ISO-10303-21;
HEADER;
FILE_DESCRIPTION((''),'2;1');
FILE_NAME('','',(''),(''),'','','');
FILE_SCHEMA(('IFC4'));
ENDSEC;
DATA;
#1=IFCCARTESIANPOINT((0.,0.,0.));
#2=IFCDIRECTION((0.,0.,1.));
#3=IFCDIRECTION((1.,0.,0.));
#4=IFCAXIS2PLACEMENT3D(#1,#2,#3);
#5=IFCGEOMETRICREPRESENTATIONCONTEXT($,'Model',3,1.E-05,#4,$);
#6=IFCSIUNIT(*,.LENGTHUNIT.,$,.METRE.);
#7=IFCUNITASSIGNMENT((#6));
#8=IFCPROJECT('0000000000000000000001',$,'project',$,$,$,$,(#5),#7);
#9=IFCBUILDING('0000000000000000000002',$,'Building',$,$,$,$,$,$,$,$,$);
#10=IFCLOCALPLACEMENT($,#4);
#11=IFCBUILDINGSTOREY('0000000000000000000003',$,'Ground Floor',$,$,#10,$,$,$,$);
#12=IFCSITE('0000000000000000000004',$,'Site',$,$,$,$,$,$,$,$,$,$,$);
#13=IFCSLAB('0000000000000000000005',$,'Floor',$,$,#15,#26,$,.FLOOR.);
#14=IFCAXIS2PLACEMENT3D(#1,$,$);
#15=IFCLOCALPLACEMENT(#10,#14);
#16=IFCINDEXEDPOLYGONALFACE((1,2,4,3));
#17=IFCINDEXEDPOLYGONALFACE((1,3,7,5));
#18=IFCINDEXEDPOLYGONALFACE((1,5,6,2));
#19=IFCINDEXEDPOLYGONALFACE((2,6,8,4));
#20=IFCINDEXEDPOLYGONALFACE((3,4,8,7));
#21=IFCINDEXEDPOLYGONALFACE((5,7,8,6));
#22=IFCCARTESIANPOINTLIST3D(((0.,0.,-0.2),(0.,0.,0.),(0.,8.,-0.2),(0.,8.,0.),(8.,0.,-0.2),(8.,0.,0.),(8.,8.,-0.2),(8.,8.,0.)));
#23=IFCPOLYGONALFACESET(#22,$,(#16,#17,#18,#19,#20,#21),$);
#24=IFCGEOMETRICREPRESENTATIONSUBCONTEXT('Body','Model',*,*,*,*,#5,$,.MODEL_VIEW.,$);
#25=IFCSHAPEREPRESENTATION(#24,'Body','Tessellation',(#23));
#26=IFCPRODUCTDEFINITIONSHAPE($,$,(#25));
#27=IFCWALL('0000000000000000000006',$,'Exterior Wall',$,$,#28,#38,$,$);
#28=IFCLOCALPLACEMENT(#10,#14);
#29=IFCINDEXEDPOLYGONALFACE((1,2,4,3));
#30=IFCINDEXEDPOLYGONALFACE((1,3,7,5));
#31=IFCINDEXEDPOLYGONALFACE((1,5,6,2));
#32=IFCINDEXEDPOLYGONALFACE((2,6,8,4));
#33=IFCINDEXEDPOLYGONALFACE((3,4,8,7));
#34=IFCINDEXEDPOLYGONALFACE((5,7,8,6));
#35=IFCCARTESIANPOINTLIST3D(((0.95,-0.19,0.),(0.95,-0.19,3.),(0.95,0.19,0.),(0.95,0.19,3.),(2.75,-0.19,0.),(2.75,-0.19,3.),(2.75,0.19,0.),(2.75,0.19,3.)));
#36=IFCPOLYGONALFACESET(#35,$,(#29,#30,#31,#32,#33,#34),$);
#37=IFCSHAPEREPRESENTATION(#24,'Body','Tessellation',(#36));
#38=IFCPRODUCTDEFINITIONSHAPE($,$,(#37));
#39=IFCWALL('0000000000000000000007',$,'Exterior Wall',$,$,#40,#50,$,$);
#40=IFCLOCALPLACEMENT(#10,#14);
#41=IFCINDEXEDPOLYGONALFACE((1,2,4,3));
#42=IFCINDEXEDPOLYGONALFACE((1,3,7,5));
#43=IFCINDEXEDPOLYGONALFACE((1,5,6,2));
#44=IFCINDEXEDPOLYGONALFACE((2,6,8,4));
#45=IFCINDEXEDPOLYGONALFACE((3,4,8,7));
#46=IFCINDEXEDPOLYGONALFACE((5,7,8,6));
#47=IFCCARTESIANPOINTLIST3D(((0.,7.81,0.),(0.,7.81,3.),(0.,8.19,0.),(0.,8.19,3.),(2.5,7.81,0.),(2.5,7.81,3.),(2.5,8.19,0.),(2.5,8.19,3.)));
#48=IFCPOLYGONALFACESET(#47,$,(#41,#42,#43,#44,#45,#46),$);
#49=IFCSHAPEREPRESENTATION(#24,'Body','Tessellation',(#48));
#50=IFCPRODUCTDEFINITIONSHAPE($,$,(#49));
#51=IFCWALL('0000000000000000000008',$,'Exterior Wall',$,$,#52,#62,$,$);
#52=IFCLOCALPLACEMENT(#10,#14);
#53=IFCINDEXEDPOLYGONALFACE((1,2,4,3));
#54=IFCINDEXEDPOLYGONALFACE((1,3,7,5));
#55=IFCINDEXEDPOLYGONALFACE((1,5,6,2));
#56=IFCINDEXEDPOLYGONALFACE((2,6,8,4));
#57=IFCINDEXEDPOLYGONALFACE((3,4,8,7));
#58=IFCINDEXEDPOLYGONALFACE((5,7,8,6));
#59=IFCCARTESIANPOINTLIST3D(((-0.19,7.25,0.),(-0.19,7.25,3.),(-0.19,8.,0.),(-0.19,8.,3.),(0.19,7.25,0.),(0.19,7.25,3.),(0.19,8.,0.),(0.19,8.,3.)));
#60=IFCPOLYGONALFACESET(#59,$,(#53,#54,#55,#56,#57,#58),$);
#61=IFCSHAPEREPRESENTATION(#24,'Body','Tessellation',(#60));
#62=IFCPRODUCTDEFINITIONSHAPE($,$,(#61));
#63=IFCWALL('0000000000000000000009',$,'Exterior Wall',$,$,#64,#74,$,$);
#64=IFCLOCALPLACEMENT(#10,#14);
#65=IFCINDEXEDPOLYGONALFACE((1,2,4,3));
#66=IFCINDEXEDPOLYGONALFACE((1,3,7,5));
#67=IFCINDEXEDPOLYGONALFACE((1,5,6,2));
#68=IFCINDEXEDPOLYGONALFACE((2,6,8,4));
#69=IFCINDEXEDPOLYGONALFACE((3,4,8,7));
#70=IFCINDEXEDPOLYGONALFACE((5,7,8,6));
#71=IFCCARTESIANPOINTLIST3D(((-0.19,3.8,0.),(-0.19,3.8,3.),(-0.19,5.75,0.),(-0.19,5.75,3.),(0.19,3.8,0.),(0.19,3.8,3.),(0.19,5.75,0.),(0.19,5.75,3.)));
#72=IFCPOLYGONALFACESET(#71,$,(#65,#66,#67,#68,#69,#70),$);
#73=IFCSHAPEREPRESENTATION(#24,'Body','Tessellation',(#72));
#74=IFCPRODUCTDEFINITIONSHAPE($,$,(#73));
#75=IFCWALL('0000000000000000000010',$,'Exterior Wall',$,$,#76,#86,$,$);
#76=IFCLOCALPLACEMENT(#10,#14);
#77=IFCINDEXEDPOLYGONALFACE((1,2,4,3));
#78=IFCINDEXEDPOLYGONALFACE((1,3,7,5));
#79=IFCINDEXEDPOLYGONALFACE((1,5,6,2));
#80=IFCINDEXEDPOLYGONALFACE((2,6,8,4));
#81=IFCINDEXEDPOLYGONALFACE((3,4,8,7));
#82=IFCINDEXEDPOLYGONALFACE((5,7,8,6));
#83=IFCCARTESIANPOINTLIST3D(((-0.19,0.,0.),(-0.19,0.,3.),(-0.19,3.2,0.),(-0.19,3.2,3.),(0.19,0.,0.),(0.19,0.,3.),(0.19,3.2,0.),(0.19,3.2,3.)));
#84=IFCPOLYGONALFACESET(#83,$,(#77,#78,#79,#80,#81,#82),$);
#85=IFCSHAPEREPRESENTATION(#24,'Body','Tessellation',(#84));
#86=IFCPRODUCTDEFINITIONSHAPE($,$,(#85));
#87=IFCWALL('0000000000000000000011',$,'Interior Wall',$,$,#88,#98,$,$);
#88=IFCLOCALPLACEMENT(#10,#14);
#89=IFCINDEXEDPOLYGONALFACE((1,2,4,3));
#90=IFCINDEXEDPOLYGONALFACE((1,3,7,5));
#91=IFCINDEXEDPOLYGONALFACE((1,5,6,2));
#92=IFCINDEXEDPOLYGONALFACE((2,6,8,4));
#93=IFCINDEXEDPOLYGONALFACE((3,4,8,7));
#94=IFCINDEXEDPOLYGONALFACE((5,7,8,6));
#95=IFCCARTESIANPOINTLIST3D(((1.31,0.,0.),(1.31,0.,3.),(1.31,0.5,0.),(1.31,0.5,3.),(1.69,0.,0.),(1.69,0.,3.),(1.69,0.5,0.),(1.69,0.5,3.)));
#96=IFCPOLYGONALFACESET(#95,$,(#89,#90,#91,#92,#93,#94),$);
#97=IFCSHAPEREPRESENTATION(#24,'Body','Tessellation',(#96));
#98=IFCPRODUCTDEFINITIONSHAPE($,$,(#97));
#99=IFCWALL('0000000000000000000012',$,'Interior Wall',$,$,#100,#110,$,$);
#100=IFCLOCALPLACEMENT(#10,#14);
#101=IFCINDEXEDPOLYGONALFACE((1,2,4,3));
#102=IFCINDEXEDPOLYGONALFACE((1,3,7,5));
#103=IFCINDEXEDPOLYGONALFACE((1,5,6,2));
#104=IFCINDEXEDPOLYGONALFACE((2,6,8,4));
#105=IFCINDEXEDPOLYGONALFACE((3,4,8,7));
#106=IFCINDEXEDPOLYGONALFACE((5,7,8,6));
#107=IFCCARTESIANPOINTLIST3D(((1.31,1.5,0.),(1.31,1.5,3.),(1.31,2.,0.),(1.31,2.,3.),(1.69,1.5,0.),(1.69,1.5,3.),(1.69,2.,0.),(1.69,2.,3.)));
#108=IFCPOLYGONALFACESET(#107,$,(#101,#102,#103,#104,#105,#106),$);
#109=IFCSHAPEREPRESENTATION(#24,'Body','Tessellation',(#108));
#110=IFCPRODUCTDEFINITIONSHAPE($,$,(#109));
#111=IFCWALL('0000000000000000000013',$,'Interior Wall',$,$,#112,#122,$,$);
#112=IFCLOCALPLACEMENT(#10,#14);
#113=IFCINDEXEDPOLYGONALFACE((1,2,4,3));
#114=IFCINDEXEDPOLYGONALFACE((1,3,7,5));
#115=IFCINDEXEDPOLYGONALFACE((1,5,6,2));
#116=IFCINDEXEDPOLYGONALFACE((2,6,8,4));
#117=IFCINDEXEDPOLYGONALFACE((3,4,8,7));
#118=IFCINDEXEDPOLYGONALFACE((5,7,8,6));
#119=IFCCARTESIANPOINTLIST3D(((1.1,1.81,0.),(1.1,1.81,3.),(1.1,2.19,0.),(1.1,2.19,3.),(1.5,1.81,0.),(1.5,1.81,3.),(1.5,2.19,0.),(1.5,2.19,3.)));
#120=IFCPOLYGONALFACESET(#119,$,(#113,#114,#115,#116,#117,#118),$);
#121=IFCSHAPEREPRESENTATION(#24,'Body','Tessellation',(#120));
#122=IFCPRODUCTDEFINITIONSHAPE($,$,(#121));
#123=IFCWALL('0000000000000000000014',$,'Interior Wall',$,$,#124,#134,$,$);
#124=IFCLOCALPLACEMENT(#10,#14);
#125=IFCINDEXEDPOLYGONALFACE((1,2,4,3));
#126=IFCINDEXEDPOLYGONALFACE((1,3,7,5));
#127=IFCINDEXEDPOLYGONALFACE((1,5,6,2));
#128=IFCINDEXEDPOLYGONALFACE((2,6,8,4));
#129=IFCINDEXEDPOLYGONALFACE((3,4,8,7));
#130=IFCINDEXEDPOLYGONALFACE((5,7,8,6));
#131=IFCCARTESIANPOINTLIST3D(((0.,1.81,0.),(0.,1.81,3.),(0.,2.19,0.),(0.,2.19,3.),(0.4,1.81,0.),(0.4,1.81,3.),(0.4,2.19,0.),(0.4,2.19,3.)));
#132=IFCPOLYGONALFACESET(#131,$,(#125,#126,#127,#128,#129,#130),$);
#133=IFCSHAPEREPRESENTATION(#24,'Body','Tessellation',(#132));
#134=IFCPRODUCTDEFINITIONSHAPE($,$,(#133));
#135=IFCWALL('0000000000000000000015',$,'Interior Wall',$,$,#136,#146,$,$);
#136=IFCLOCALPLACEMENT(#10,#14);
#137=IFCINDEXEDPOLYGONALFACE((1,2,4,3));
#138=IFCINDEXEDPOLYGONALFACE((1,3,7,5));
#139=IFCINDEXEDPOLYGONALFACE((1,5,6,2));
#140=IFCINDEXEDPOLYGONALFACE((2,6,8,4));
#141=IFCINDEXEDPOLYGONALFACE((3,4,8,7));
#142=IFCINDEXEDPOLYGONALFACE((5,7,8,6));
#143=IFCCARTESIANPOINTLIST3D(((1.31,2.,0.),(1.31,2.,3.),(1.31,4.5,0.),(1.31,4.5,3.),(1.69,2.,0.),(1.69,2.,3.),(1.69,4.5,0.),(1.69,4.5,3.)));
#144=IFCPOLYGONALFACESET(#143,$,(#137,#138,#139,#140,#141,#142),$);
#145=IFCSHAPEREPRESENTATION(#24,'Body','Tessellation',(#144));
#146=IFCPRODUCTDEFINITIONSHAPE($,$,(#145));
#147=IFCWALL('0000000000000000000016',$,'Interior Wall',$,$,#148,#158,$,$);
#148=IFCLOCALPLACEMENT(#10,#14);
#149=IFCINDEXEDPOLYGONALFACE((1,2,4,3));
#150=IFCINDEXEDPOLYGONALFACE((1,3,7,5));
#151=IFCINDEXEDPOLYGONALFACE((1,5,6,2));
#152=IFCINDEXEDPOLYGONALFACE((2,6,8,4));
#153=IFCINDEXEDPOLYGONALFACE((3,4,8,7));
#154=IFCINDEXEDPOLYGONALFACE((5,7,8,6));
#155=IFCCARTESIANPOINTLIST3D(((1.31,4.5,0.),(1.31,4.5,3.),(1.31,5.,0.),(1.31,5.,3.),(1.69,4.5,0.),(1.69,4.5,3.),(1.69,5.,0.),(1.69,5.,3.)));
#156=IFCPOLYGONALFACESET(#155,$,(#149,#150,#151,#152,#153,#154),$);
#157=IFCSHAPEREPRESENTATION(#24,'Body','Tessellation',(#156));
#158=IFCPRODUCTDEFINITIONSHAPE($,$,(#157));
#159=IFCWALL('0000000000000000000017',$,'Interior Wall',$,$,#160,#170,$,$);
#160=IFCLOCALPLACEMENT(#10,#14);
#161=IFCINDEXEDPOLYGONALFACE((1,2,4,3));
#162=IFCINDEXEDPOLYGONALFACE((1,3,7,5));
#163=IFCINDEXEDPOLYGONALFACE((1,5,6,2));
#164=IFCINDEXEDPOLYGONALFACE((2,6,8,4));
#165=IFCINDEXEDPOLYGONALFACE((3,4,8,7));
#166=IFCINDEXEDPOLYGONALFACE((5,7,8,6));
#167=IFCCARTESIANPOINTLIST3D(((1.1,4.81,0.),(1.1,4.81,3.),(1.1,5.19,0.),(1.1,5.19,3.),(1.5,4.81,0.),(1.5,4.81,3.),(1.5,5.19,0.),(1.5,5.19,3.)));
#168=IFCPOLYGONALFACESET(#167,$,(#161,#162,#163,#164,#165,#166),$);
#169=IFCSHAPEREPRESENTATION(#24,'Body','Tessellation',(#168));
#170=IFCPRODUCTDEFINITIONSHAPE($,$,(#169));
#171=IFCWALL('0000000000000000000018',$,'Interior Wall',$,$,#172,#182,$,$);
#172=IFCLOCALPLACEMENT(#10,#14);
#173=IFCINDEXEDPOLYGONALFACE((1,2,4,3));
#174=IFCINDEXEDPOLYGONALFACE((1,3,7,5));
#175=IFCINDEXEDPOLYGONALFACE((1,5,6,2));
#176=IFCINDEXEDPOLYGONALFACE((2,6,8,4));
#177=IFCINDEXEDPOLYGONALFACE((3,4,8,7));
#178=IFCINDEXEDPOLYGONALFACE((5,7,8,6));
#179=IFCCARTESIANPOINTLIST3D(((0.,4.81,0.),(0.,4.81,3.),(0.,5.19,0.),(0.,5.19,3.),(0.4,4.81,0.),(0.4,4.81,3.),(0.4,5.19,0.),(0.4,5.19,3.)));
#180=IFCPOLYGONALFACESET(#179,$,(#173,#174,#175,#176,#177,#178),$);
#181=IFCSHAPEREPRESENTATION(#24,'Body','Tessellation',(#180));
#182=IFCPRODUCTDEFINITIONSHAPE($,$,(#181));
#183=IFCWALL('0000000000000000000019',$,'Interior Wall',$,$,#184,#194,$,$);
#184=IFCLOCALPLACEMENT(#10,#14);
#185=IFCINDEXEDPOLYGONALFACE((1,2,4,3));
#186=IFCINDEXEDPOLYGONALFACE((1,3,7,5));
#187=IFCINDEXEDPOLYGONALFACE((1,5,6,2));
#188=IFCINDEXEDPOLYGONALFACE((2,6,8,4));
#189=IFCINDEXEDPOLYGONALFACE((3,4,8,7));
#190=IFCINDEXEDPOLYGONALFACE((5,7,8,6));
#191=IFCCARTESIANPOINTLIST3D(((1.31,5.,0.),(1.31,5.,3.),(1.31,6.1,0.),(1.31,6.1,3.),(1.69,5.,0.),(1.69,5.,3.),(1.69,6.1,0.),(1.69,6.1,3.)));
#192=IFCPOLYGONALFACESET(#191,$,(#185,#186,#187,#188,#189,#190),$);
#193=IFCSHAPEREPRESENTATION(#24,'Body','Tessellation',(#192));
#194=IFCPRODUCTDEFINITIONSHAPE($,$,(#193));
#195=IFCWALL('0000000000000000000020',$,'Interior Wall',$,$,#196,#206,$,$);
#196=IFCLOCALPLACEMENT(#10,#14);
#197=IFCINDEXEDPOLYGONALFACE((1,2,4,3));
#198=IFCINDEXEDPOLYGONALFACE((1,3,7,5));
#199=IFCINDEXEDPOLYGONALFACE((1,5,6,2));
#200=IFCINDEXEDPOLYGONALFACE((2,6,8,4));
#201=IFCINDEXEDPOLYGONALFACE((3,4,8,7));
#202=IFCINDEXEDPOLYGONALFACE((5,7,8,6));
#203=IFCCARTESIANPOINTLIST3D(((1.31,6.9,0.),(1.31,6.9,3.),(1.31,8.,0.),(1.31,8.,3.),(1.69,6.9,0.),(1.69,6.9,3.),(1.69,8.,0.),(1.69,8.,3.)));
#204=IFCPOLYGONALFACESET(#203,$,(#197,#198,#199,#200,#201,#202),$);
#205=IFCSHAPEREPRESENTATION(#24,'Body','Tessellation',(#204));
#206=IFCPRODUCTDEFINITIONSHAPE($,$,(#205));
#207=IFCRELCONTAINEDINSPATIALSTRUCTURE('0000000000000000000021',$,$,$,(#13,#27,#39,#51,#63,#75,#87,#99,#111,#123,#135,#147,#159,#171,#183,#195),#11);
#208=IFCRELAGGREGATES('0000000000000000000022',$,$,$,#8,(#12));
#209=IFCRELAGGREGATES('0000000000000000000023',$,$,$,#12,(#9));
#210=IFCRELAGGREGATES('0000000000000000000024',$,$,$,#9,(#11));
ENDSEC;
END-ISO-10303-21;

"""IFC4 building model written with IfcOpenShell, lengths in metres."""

from ifc_helpers import new_model, si_unit, frame, origin_with_axes, place, context, subcontext, project, spatial, indexed_curve, outline, extrude, element, save


model = new_model("IFC4")

# Units and contexts
model_context = context("Model", 3, precision=1e-05, world=origin_with_axes())
body_context = subcontext(model_context, "Body", "Model", "MODEL_VIEW")
ifc_project = project(units=[si_unit("LENGTHUNIT", "METRE")], contexts=[model_context])

# Site, building, storey
site = spatial("IfcSite", under=ifc_project, Name="Site")
building = spatial("IfcBuilding", under=site, Name="Building")
storey_placement = place(None, origin_with_axes())
storey = spatial("IfcBuildingStorey", under=building, at=storey_placement, Name="Ground Floor")

# Slab
slab_placement = place(storey_placement, frame((0.0, 0.0, -0.2), z_axis=(0.0, 0.0, 1.0), x_axis=(1.0, 0.0, 0.0)))
element("IfcSlab", 1, at=slab_placement, inside=storey, Name="Floor", PredefinedType="FLOOR", context=body_context, shape_type="SweptSolid", body=[
    extrude(outline(indexed_curve([(0.0, 0.0), (8.0, 0.0), (8.0, 8.0), (0.0, 8.0)])), None, (0.0, 0.0, 1.0), 0.2),
])

# Walls
wall_1_placement = place(storey_placement, frame((0.95, 0.0, 0.0), z_axis=(0.0, 0.0, 1.0), x_axis=(1.0, 0.0, 0.0)))
element("IfcWall", 2, at=wall_1_placement, inside=storey, Name="Exterior Wall", context=body_context, shape_type="SweptSolid", body=[
    extrude(outline(indexed_curve([(0.0, 0.0), (0.0, 0.38), (1.8, 0.38), (1.8, 0.0), (0.0, 0.0)], self_intersect=False)), frame((0.0, -0.19, 0.0), z_axis=(0.0, 0.0, 1.0), x_axis=(1.0, 0.0, 0.0)), (0.0, 0.0, 1.0), 3.0),
])
wall_2_placement = place(storey_placement, frame((2.5, 8.0, 0.0), z_axis=(0.0, 0.0, 1.0), x_axis=(-1.0, 0.0, 0.0)))
element("IfcWall", 3, at=wall_2_placement, inside=storey, Name="Exterior Wall", context=body_context, shape_type="SweptSolid", body=[
    extrude(outline(indexed_curve([(0.0, 0.0), (0.0, 0.38), (2.5, 0.38), (2.5, 0.0), (0.0, 0.0)], self_intersect=False)), frame((0.0, -0.19, 0.0), z_axis=(0.0, 0.0, 1.0), x_axis=(1.0, 0.0, 0.0)), (0.0, 0.0, 1.0), 3.0),
])
wall_3_placement = place(storey_placement, frame((0.0, 8.0, 0.0), z_axis=(0.0, 0.0, 1.0), x_axis=(0.0, -1.0, 0.0)))
element("IfcWall", 4, at=wall_3_placement, inside=storey, Name="Exterior Wall", context=body_context, shape_type="SweptSolid", body=[
    extrude(outline(indexed_curve([(0.0, 0.0), (0.0, 0.38), (0.75, 0.38), (0.75, 0.0), (0.0, 0.0)], self_intersect=False)), frame((0.0, -0.19, 0.0), z_axis=(0.0, 0.0, 1.0), x_axis=(1.0, 0.0, 0.0)), (0.0, 0.0, 1.0), 3.0),
])
wall_4_placement = place(storey_placement, frame((0.0, 5.75, 0.0), z_axis=(0.0, 0.0, 1.0), x_axis=(0.0, -1.0, 0.0)))
element("IfcWall", 5, at=wall_4_placement, inside=storey, Name="Exterior Wall", context=body_context, shape_type="SweptSolid", body=[
    extrude(outline(indexed_curve([(0.0, 0.0), (0.0, 0.38), (1.95, 0.38), (1.95, 0.0), (0.0, 0.0)], self_intersect=False)), frame((0.0, -0.19, 0.0), z_axis=(0.0, 0.0, 1.0), x_axis=(1.0, 0.0, 0.0)), (0.0, 0.0, 1.0), 3.0),
])
wall_5_placement = place(storey_placement, frame((0.0, 3.2, 0.0), z_axis=(0.0, 0.0, 1.0), x_axis=(0.0, -1.0, 0.0)))
element("IfcWall", 6, at=wall_5_placement, inside=storey, Name="Exterior Wall", context=body_context, shape_type="SweptSolid", body=[
    extrude(outline(indexed_curve([(0.0, 0.0), (0.0, 0.38), (3.2, 0.38), (3.2, 0.0), (0.0, 0.0)], self_intersect=False)), frame((0.0, -0.19, 0.0), z_axis=(0.0, 0.0, 1.0), x_axis=(1.0, 0.0, 0.0)), (0.0, 0.0, 1.0), 3.0),
])
for number, where, z_axis, x_axis, name in (
    (7, (1.5, 0.0, 0.0), (0.0, 0.0, 1.0), (0.0, 1.0, 0.0), "Interior Wall"),
    (8, (1.5, 1.5, 0.0), (0.0, 0.0, 1.0), (0.0, 1.0, 0.0), "Interior Wall"),
):
    element("IfcWall", number, at=place(storey_placement, frame(where, z_axis=z_axis, x_axis=x_axis)), inside=storey, Name=name, context=body_context, shape_type="SweptSolid", body=[
        extrude(outline(indexed_curve([(0.0, 0.0), (0.0, 0.38), (0.5, 0.38), (0.5, 0.0), (0.0, 0.0)], self_intersect=False)), frame((0.0, -0.19, 0.0), z_axis=(0.0, 0.0, 1.0), x_axis=(1.0, 0.0, 0.0)), (0.0, 0.0, 1.0), 3.0),
    ])
for number, where, z_axis, x_axis, name in (
    (9, (1.5, 2.0, 0.0), (0.0, 0.0, 1.0), (-1.0, 0.0, 0.0), "Interior Wall"),
    (10, (0.4, 2.0, 0.0), (0.0, 0.0, 1.0), (-1.0, 0.0, 0.0), "Interior Wall"),
):
    element("IfcWall", number, at=place(storey_placement, frame(where, z_axis=z_axis, x_axis=x_axis)), inside=storey, Name=name, context=body_context, shape_type="SweptSolid", body=[
        extrude(outline(indexed_curve([(0.0, 0.0), (0.0, 0.38), (0.4, 0.38), (0.4, 0.0), (0.0, 0.0)], self_intersect=False)), frame((0.0, -0.19, 0.0), z_axis=(0.0, 0.0, 1.0), x_axis=(1.0, 0.0, 0.0)), (0.0, 0.0, 1.0), 3.0),
    ])
wall_6_placement = place(storey_placement, frame((1.5, 4.5, 0.0), z_axis=(0.0, 0.0, 1.0), x_axis=(0.0, -1.0, 0.0)))
element("IfcWall", 11, at=wall_6_placement, inside=storey, Name="Interior Wall", context=body_context, shape_type="SweptSolid", body=[
    extrude(outline(indexed_curve([(0.0, 0.0), (0.0, 0.38), (2.5, 0.38), (2.5, 0.0), (0.0, 0.0)], self_intersect=False)), frame((0.0, -0.19, 0.0), z_axis=(0.0, 0.0, 1.0), x_axis=(1.0, 0.0, 0.0)), (0.0, 0.0, 1.0), 3.0),
])
wall_7_placement = place(storey_placement, frame((1.5, 4.5, 0.0), z_axis=(0.0, 0.0, 1.0), x_axis=(0.0, 1.0, 0.0)))
element("IfcWall", 12, at=wall_7_placement, inside=storey, Name="Interior Wall", context=body_context, shape_type="SweptSolid", body=[
    extrude(outline(indexed_curve([(0.0, 0.0), (0.0, 0.38), (0.5, 0.38), (0.5, 0.0), (0.0, 0.0)], self_intersect=False)), frame((0.0, -0.19, 0.0), z_axis=(0.0, 0.0, 1.0), x_axis=(1.0, 0.0, 0.0)), (0.0, 0.0, 1.0), 3.0),
])
for number, where, z_axis, x_axis, name in (
    (13, (1.5, 5.0, 0.0), (0.0, 0.0, 1.0), (-1.0, 0.0, 0.0), "Interior Wall"),
    (14, (0.4, 5.0, 0.0), (0.0, 0.0, 1.0), (-1.0, 0.0, 0.0), "Interior Wall"),
):
    element("IfcWall", number, at=place(storey_placement, frame(where, z_axis=z_axis, x_axis=x_axis)), inside=storey, Name=name, context=body_context, shape_type="SweptSolid", body=[
        extrude(outline(indexed_curve([(0.0, 0.0), (0.0, 0.38), (0.4, 0.38), (0.4, 0.0), (0.0, 0.0)], self_intersect=False)), frame((0.0, -0.19, 0.0), z_axis=(0.0, 0.0, 1.0), x_axis=(1.0, 0.0, 0.0)), (0.0, 0.0, 1.0), 3.0),
    ])
for number, where, z_axis, x_axis, name in (
    (15, (1.5, 5.0, 0.0), (0.0, 0.0, 1.0), (0.0, 1.0, 0.0), "Interior Wall"),
    (16, (1.5, 6.9, 0.0), (0.0, 0.0, 1.0), (0.0, 1.0, 0.0), "Interior Wall"),
):
    element("IfcWall", number, at=place(storey_placement, frame(where, z_axis=z_axis, x_axis=x_axis)), inside=storey, Name=name, context=body_context, shape_type="SweptSolid", body=[
        extrude(outline(indexed_curve([(0.0, 0.0), (0.0, 0.38), (1.1, 0.38), (1.1, 0.0), (0.0, 0.0)], self_intersect=False)), frame((0.0, -0.19, 0.0), z_axis=(0.0, 0.0, 1.0), x_axis=(1.0, 0.0, 0.0)), (0.0, 0.0, 1.0), 3.0),
    ])

save(model, "model.ifc")
